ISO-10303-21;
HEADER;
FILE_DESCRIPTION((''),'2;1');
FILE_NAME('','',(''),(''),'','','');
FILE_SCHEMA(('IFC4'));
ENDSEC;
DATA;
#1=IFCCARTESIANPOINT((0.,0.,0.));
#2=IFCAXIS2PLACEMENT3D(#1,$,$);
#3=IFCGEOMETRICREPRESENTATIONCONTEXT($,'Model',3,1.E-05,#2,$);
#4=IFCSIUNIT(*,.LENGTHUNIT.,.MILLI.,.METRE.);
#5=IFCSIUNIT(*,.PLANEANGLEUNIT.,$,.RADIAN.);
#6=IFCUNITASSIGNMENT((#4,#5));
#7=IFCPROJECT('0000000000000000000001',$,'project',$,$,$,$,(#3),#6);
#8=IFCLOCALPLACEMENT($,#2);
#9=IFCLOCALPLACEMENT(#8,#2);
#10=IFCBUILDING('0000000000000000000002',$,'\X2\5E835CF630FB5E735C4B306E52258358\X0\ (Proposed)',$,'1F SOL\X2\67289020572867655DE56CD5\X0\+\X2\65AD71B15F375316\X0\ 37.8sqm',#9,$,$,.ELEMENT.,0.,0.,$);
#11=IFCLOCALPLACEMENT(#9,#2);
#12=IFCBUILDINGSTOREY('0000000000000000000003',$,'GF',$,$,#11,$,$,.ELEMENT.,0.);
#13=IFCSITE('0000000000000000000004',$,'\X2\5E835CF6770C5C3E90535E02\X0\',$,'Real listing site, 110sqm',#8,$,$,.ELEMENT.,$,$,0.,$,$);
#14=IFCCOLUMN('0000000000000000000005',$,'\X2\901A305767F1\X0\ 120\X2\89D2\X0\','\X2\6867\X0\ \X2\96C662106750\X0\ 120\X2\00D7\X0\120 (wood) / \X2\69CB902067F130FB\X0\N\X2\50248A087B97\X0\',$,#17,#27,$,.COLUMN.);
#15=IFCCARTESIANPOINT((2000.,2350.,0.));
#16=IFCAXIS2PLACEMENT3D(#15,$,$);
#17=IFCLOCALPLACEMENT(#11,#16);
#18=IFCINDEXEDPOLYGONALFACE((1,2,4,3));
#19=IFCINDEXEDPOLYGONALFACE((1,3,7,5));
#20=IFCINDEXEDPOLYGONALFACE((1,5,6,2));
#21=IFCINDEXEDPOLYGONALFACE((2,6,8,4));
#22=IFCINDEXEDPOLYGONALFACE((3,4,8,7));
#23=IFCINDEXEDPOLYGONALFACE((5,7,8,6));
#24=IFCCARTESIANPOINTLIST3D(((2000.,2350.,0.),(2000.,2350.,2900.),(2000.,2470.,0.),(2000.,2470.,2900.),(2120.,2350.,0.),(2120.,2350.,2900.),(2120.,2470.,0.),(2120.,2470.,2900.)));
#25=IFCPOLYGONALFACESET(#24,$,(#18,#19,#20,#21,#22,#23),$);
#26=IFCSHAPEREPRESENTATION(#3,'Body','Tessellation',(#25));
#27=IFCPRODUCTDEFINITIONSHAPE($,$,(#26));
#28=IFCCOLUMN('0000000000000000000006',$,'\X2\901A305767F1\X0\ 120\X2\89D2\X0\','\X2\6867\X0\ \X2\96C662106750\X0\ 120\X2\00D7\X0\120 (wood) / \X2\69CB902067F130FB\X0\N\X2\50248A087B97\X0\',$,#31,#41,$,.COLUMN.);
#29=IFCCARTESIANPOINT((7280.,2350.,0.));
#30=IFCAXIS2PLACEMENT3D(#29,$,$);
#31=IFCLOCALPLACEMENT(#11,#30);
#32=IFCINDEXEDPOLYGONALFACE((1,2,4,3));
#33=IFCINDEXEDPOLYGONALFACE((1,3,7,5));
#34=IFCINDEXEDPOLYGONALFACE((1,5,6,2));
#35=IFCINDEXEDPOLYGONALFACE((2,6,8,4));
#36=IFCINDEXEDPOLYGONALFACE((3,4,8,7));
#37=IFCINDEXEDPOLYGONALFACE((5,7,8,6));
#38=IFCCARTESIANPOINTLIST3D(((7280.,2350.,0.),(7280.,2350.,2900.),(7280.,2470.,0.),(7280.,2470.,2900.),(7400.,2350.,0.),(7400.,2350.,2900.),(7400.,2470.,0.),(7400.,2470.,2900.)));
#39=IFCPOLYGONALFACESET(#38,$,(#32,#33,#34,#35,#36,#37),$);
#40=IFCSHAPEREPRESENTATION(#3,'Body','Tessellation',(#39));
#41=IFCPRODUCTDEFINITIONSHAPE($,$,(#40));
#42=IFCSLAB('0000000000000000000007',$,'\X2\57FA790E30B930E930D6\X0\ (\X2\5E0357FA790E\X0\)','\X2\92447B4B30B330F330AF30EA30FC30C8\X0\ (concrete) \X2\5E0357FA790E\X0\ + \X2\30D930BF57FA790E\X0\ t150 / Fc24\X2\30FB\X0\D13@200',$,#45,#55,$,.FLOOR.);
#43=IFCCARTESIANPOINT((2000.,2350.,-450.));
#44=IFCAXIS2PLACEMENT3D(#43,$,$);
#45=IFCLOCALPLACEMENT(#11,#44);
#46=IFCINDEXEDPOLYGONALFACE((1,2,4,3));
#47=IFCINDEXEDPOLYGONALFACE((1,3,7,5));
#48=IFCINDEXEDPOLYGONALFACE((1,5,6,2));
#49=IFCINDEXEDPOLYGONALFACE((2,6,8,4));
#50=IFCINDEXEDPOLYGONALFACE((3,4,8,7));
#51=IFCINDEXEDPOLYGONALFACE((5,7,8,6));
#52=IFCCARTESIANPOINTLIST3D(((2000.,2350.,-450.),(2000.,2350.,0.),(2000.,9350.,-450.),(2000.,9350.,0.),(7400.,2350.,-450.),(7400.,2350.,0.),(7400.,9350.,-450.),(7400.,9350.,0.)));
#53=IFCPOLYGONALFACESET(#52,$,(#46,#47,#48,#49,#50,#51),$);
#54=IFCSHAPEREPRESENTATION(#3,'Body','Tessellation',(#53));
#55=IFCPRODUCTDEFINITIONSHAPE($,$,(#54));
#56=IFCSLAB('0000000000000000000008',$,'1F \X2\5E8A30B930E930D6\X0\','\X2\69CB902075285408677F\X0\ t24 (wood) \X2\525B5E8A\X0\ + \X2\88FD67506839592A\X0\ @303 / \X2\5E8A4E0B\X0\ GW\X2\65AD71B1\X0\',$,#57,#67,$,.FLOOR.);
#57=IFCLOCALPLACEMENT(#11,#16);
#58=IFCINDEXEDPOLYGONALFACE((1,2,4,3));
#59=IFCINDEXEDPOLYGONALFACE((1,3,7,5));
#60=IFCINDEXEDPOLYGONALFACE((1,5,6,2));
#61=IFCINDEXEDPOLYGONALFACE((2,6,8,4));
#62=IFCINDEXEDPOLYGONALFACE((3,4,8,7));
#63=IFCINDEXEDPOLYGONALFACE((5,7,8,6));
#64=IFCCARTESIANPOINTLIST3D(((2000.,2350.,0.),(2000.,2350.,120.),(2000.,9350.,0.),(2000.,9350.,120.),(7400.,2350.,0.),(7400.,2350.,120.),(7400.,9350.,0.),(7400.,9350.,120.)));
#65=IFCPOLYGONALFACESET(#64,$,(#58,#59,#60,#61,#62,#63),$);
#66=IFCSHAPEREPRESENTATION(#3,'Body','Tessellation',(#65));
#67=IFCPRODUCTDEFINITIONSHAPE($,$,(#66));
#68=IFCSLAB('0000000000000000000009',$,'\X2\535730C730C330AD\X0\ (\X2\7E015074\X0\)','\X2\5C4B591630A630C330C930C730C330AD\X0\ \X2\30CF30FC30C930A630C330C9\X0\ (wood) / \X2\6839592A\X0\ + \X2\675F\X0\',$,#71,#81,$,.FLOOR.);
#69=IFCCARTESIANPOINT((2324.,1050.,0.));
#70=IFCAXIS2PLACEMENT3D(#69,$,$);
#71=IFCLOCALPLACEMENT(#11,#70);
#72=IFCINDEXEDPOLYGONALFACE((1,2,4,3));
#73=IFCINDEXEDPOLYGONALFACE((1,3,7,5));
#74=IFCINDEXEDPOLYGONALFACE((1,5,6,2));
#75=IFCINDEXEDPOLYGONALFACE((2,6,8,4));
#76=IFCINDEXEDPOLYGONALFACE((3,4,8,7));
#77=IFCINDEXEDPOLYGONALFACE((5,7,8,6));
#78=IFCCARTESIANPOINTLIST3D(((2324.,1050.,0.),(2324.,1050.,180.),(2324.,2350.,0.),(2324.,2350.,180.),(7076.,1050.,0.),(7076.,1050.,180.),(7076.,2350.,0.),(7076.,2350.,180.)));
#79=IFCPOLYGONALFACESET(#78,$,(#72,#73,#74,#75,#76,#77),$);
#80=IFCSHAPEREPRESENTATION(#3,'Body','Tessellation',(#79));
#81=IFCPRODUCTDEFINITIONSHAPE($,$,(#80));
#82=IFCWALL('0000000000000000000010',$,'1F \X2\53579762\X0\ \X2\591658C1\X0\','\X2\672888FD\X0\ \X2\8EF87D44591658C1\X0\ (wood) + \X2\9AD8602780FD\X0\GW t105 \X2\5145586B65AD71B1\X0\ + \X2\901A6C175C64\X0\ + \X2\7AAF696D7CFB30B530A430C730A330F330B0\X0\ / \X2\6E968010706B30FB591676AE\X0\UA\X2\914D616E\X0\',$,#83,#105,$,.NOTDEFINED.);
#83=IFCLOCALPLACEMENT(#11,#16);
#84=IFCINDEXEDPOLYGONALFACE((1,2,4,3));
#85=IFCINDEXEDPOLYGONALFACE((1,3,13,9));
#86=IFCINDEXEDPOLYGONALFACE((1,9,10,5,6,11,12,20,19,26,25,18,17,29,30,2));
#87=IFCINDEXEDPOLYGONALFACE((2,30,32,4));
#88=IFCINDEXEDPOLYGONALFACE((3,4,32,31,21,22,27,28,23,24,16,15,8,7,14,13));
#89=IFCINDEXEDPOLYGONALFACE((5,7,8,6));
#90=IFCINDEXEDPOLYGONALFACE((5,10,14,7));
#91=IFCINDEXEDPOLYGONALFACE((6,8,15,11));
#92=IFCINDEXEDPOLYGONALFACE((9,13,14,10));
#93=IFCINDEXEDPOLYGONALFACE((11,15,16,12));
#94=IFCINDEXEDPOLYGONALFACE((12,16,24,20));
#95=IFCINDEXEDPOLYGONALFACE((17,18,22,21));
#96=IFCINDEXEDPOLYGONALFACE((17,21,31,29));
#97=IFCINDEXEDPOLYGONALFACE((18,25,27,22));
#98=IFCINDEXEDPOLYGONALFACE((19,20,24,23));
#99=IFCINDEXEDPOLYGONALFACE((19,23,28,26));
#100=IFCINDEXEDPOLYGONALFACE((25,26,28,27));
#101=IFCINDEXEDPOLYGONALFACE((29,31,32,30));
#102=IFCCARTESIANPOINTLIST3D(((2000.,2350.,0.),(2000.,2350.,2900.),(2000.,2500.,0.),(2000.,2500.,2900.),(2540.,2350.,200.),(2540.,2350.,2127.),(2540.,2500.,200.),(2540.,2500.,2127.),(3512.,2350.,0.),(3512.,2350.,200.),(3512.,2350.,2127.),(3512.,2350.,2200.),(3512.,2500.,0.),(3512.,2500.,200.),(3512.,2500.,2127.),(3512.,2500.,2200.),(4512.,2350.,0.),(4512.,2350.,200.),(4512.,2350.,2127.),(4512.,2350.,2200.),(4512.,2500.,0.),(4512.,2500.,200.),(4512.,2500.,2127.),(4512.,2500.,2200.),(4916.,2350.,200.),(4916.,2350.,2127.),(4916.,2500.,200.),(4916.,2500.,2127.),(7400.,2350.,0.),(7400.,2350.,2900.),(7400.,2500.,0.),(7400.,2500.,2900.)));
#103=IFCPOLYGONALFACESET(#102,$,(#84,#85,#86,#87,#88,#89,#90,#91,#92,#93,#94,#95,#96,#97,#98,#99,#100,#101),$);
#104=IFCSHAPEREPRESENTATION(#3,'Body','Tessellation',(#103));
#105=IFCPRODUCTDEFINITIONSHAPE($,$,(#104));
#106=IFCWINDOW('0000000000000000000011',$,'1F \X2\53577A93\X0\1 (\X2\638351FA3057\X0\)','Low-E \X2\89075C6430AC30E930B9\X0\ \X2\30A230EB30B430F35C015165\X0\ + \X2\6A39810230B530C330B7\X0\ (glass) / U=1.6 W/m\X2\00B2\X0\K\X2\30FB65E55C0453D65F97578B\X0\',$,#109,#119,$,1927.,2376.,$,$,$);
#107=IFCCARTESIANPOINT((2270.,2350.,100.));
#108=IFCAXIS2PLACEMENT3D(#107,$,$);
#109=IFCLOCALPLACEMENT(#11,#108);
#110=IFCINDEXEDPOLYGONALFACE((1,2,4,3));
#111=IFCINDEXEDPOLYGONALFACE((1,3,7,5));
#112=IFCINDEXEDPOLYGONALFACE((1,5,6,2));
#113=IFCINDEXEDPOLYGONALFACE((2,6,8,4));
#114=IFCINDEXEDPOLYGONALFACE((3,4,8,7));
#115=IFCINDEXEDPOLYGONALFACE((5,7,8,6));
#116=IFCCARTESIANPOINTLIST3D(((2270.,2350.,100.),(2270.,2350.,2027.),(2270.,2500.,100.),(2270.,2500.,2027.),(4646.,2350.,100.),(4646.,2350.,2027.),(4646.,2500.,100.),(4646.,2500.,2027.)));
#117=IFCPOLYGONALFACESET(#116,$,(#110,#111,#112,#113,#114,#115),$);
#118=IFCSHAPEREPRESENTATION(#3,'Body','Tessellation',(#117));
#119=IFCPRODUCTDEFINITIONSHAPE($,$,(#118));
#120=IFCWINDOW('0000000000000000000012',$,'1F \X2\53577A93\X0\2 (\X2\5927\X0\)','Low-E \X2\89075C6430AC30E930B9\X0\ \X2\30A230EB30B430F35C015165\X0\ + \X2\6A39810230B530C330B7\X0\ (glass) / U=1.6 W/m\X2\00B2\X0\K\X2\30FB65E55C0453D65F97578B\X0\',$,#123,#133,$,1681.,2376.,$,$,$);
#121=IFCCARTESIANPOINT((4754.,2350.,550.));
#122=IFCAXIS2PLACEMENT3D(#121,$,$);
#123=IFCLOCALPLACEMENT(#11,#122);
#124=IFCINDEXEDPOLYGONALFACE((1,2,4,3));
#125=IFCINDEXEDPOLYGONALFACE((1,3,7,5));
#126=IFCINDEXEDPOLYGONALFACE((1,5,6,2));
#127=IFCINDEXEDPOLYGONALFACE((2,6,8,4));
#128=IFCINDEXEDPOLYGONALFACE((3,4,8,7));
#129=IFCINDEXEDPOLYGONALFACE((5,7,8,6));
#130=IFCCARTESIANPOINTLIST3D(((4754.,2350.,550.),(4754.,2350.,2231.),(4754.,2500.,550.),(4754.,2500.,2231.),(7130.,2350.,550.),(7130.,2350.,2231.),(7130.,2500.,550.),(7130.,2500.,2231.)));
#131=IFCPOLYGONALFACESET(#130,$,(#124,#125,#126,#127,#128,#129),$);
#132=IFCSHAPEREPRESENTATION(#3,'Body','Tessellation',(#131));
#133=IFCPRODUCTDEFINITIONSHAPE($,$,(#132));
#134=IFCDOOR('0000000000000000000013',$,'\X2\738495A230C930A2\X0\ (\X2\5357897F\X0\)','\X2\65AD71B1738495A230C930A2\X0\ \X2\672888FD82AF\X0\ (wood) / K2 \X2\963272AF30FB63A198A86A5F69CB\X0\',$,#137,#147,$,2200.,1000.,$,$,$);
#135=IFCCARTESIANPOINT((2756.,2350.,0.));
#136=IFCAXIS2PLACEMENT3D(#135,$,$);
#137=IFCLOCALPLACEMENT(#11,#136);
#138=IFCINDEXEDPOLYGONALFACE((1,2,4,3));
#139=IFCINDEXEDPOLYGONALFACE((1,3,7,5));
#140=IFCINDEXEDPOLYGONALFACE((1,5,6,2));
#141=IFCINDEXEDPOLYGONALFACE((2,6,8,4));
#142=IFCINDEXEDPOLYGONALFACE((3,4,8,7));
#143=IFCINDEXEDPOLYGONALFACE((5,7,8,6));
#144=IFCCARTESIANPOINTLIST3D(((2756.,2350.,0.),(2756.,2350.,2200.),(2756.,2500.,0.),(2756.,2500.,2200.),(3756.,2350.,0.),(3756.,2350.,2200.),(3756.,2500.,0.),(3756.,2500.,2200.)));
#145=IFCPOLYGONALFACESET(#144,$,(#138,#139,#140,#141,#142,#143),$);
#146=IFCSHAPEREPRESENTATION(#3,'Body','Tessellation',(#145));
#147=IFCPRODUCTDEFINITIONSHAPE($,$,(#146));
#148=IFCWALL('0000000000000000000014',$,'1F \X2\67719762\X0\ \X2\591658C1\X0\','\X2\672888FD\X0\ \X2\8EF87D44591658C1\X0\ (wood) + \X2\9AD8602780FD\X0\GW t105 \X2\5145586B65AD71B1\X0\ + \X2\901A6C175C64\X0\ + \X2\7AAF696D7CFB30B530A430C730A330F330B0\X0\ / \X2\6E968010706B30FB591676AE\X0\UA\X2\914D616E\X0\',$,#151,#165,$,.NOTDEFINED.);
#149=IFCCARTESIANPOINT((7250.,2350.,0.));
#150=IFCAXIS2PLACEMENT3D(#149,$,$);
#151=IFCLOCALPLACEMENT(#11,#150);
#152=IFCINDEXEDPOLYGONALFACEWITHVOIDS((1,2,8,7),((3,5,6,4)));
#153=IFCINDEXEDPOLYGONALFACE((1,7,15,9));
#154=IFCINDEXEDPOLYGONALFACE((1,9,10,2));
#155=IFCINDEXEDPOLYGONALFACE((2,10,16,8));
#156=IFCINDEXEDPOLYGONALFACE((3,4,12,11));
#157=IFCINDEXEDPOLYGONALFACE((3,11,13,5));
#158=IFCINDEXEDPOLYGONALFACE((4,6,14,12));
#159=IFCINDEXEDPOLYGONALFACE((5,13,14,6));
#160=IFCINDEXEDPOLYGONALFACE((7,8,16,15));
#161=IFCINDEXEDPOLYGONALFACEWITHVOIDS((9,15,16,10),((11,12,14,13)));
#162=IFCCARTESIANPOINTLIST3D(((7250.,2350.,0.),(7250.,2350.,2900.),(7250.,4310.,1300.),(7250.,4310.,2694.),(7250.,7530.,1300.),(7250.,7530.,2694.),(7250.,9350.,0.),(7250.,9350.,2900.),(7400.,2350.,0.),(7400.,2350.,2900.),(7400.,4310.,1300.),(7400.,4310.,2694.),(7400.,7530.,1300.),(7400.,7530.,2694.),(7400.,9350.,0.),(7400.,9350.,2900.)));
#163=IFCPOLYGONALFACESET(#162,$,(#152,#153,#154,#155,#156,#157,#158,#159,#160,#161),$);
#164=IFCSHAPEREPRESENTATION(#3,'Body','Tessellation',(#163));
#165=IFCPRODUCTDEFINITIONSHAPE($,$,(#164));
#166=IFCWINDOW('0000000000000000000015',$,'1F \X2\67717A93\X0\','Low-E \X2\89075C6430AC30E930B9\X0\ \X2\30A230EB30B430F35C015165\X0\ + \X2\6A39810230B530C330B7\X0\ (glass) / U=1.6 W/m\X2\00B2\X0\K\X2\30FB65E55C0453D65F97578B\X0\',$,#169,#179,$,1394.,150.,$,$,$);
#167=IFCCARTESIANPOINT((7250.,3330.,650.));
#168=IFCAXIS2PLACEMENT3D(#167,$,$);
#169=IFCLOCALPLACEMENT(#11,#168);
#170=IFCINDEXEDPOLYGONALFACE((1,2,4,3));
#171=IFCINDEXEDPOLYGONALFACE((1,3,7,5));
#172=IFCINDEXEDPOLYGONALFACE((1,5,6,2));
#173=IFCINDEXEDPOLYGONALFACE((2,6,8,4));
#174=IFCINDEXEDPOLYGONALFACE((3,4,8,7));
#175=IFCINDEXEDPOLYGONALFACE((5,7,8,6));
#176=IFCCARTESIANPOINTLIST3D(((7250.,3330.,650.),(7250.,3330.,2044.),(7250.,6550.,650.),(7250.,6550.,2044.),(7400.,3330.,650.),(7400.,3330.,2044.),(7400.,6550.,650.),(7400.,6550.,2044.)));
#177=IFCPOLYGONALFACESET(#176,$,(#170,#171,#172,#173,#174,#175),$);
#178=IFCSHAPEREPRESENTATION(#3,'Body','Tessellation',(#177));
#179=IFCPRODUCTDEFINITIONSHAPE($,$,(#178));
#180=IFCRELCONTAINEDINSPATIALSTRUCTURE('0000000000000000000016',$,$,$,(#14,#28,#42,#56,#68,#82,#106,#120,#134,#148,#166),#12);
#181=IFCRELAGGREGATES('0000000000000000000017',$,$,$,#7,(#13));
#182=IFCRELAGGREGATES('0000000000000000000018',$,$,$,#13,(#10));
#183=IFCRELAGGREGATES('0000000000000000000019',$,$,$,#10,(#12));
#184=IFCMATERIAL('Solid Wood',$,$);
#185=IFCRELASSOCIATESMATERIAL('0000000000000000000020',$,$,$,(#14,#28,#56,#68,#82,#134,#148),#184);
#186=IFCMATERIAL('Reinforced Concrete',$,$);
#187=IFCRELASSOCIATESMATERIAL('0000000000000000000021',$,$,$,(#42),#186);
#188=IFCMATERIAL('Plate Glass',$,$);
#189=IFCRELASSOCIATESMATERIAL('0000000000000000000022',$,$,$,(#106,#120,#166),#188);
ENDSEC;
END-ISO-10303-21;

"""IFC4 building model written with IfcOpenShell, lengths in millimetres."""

from ifc_helpers import new_model, si_unit, frame, frame_2d, origin, place, context, project, spatial, rectangle, extrude, material, element, fill, save


model = new_model("IFC4")

# Units and contexts
model_context = context("Model", 3, precision=1e-05, world=origin())
ifc_project = project(units=[si_unit("LENGTHUNIT", "METRE", prefix="MILLI"), si_unit("PLANEANGLEUNIT", "RADIAN")], contexts=[model_context])

# Site, building, storey
site_placement = place(None, origin())
site = spatial("IfcSite", under=ifc_project, at=site_placement, Name="広島県尾道市", ObjectType="Real listing site, 110sqm", CompositionType="ELEMENT", RefElevation=0.0)
building_placement = place(site_placement, origin())
building = spatial("IfcBuilding", under=site, at=building_placement, Name="広島・平屋の別荘 (Proposed)", ObjectType="1F SOL木造在来工法+断熱強化 37.8sqm", CompositionType="ELEMENT", ElevationOfRefHeight=0.0, ElevationOfTerrain=0.0)
storey_placement = place(building_placement, origin())
storey = spatial("IfcBuildingStorey", under=building, at=storey_placement, Name="GF", CompositionType="ELEMENT", Elevation=0.0)

# Columns
ifc_material_1 = material(Name="Solid Wood")
column_1_placement = place(storey_placement, frame((2000.0, 2350.0, 0.0)))
element("IfcColumn", 1, at=column_1_placement, inside=storey, material=ifc_material_1, Name="通し柱 120角", Description="桧 集成材 120×120 (wood) / 構造柱・N値計算", PredefinedType="COLUMN", context=model_context, shape_type="SweptSolid", body=[
    extrude(rectangle(XDim=120.0, YDim=120.0, at=frame_2d((60.0, 60.0))), frame((2000.0, 2350.0, 0.0)), (0.0, 0.0, 1.0), 2900.0),
])
column_2_placement = place(storey_placement, frame((7280.0, 2350.0, 0.0)))
element("IfcColumn", 2, at=column_2_placement, inside=storey, material=ifc_material_1, Name="通し柱 120角", Description="桧 集成材 120×120 (wood) / 構造柱・N値計算", PredefinedType="COLUMN", context=model_context, shape_type="SweptSolid", body=[
    extrude(rectangle(XDim=120.0, YDim=120.0, at=frame_2d((60.0, 60.0))), frame((7280.0, 2350.0, 0.0)), (0.0, 0.0, 1.0), 2900.0),
])

# Slabs
ifc_material_2 = material(Name="Reinforced Concrete")
slab_1_placement = place(storey_placement, frame((2000.0, 2350.0, -450.0)))
element("IfcSlab", 3, at=slab_1_placement, inside=storey, material=ifc_material_2, Name="基礎スラブ (布基礎)", Description="鉄筋コンクリート (concrete) 布基礎 + ベタ基礎 t150 / Fc24・D13@200", PredefinedType="FLOOR", context=model_context, shape_type="SweptSolid", body=[
    extrude(rectangle(XDim=5400.0, YDim=7000.0, at=frame_2d((2700.0, 3500.0))), frame((2000.0, 2350.0, -450.0)), (0.0, 0.0, 1.0), 450.0),
])
slab_2_placement = place(storey_placement, frame((2000.0, 2350.0, 0.0)))
element("IfcSlab", 4, at=slab_2_placement, inside=storey, material=ifc_material_1, Name="1F 床スラブ", Description="構造用合板 t24 (wood) 剛床 + 製材根太 @303 / 床下 GW断熱", PredefinedType="FLOOR", context=model_context, shape_type="SweptSolid", body=[
    extrude(rectangle(XDim=5400.0, YDim=7000.0, at=frame_2d((2700.0, 3500.0))), frame((2000.0, 2350.0, 0.0)), (0.0, 0.0, 1.0), 120.0),
])
slab_3_placement = place(storey_placement, frame((2324.0, 1050.0, 0.0)))
element("IfcSlab", 5, at=slab_3_placement, inside=storey, material=ifc_material_1, Name="南デッキ (縁側)", Description="屋外ウッドデッキ ハードウッド (wood) / 根太 + 束", PredefinedType="FLOOR", context=model_context, shape_type="SweptSolid", body=[
    extrude(rectangle(XDim=4752.0, YDim=1300.0, at=frame_2d((2376.0, 650.0))), frame((2324.0, 1050.0, 0.0)), (0.0, 0.0, 1.0), 180.0),
])

# Wall, openings, windows, door
wall_1_placement = place(storey_placement, frame((2000.0, 2350.0, 0.0)))
wall_1 = element("IfcWall", 6, at=wall_1_placement, inside=storey, material=ifc_material_1, Name="1F 南面 外壁", Description="木製 軸組外壁 (wood) + 高性能GW t105 充填断熱 + 通気層 + 窯業系サイディング / 準耐火・外皮UA配慮", PredefinedType="NOTDEFINED", context=model_context, shape_type="SweptSolid", body=[
    extrude(rectangle(XDim=5400.0, YDim=150.0, at=frame_2d((2700.0, 75.0))), frame((2000.0, 2350.0, 0.0)), (0.0, 0.0, 1.0), 2900.0),
])
opening_1_placement = place(storey_placement, frame((2270.0, 2350.0, 100.0)))
opening_1 = element("IfcOpeningElement", 7, at=opening_1_placement, cuts=wall_1, PredefinedType="NOTDEFINED", context=model_context, shape_type="SweptSolid", body=[
    extrude(rectangle(XDim=2376.0, YDim=150.0, at=frame_2d((1188.0, 75.0))), frame((2270.0, 2350.0, 100.0)), (0.0, 0.0, 1.0), 1927.0),
])
opening_2_placement = place(storey_placement, frame((4754.0, 2350.0, 550.0)))
opening_2 = element("IfcOpeningElement", 8, at=opening_2_placement, cuts=wall_1, PredefinedType="NOTDEFINED", context=model_context, shape_type="SweptSolid", body=[
    extrude(rectangle(XDim=2376.0, YDim=150.0, at=frame_2d((1188.0, 75.0))), frame((4754.0, 2350.0, 550.0)), (0.0, 0.0, 1.0), 1681.0),
])
opening_3_placement = place(storey_placement, frame((2756.0, 2350.0, 0.0)))
opening_3 = element("IfcOpeningElement", 9, at=opening_3_placement, cuts=wall_1, PredefinedType="NOTDEFINED", context=model_context, shape_type="SweptSolid", body=[
    extrude(rectangle(XDim=1000.0, YDim=150.0, at=frame_2d((500.0, 75.0))), frame((2756.0, 2350.0, 0.0)), (0.0, 0.0, 1.0), 2200.0),
])
ifc_material_3 = material(Name="Plate Glass")
window_1_placement = place(storey_placement, frame((2270.0, 2350.0, 100.0)))
window_1 = element("IfcWindow", 10, at=window_1_placement, inside=storey, material=ifc_material_3, Name="1F 南窓1 (掃出し)", Description="Low-E 複層ガラス アルゴン封入 + 樹脂サッシ (glass) / U=1.6 W/m²K・日射取得型", OverallHeight=1927.0, OverallWidth=2376.0, context=model_context, shape_type="SweptSolid", body=[
    extrude(rectangle(XDim=2376.0, YDim=150.0, at=frame_2d((1188.0, 75.0))), frame((2270.0, 2350.0, 100.0)), (0.0, 0.0, 1.0), 1927.0),
])
fill(opening_1, window_1)
window_2_placement = place(storey_placement, frame((4754.0, 2350.0, 550.0)))
window_2 = element("IfcWindow", 11, at=window_2_placement, inside=storey, material=ifc_material_3, Name="1F 南窓2 (大)", Description="Low-E 複層ガラス アルゴン封入 + 樹脂サッシ (glass) / U=1.6 W/m²K・日射取得型", OverallHeight=1681.0, OverallWidth=2376.0, context=model_context, shape_type="SweptSolid", body=[
    extrude(rectangle(XDim=2376.0, YDim=150.0, at=frame_2d((1188.0, 75.0))), frame((4754.0, 2350.0, 550.0)), (0.0, 0.0, 1.0), 1681.0),
])
fill(opening_2, window_2)
door_placement = place(storey_placement, frame((2756.0, 2350.0, 0.0)))
door = element("IfcDoor", 12, at=door_placement, inside=storey, material=ifc_material_1, Name="玄関ドア (南西)", Description="断熱玄関ドア 木製芯 (wood) / K2 防犯・採風機構", OverallHeight=2200.0, OverallWidth=1000.0, context=model_context, shape_type="SweptSolid", body=[
    extrude(rectangle(XDim=1000.0, YDim=150.0, at=frame_2d((500.0, 75.0))), frame((2756.0, 2350.0, 0.0)), (0.0, 0.0, 1.0), 2200.0),
])
fill(opening_3, door)

# Wall, opening, window
wall_2_placement = place(storey_placement, frame((7250.0, 2350.0, 0.0)))
wall_2 = element("IfcWall", 13, at=wall_2_placement, inside=storey, material=ifc_material_1, Name="1F 東面 外壁", Description="木製 軸組外壁 (wood) + 高性能GW t105 充填断熱 + 通気層 + 窯業系サイディング / 準耐火・外皮UA配慮", PredefinedType="NOTDEFINED", context=model_context, shape_type="SweptSolid", body=[
    extrude(rectangle(XDim=150.0, YDim=7000.0, at=frame_2d((75.0, 3500.0))), frame((7250.0, 2350.0, 0.0)), (0.0, 0.0, 1.0), 2900.0),
])
opening_4_placement = place(storey_placement, frame((7250.0, 3330.0, 650.0)))
opening_4 = element("IfcOpeningElement", 14, at=opening_4_placement, cuts=wall_2, PredefinedType="NOTDEFINED", context=model_context, shape_type="SweptSolid", body=[
    extrude(rectangle(XDim=150.0, YDim=3220.0, at=frame_2d((75.0, 1610.0))), frame((7250.0, 3330.0, 650.0)), (0.0, 0.0, 1.0), 1394.0),
])
window_3_placement = place(storey_placement, frame((7250.0, 3330.0, 650.0)))
window_3 = element("IfcWindow", 15, at=window_3_placement, inside=storey, material=ifc_material_3, Name="1F 東窓", Description="Low-E 複層ガラス アルゴン封入 + 樹脂サッシ (glass) / U=1.6 W/m²K・日射取得型", OverallHeight=1394.0, OverallWidth=150.0, context=model_context, shape_type="SweptSolid", body=[
    extrude(rectangle(XDim=150.0, YDim=3220.0, at=frame_2d((75.0, 1610.0))), frame((7250.0, 3330.0, 650.0)), (0.0, 0.0, 1.0), 1394.0),
])
fill(opening_4, window_3)

save(model, "model.ifc")
